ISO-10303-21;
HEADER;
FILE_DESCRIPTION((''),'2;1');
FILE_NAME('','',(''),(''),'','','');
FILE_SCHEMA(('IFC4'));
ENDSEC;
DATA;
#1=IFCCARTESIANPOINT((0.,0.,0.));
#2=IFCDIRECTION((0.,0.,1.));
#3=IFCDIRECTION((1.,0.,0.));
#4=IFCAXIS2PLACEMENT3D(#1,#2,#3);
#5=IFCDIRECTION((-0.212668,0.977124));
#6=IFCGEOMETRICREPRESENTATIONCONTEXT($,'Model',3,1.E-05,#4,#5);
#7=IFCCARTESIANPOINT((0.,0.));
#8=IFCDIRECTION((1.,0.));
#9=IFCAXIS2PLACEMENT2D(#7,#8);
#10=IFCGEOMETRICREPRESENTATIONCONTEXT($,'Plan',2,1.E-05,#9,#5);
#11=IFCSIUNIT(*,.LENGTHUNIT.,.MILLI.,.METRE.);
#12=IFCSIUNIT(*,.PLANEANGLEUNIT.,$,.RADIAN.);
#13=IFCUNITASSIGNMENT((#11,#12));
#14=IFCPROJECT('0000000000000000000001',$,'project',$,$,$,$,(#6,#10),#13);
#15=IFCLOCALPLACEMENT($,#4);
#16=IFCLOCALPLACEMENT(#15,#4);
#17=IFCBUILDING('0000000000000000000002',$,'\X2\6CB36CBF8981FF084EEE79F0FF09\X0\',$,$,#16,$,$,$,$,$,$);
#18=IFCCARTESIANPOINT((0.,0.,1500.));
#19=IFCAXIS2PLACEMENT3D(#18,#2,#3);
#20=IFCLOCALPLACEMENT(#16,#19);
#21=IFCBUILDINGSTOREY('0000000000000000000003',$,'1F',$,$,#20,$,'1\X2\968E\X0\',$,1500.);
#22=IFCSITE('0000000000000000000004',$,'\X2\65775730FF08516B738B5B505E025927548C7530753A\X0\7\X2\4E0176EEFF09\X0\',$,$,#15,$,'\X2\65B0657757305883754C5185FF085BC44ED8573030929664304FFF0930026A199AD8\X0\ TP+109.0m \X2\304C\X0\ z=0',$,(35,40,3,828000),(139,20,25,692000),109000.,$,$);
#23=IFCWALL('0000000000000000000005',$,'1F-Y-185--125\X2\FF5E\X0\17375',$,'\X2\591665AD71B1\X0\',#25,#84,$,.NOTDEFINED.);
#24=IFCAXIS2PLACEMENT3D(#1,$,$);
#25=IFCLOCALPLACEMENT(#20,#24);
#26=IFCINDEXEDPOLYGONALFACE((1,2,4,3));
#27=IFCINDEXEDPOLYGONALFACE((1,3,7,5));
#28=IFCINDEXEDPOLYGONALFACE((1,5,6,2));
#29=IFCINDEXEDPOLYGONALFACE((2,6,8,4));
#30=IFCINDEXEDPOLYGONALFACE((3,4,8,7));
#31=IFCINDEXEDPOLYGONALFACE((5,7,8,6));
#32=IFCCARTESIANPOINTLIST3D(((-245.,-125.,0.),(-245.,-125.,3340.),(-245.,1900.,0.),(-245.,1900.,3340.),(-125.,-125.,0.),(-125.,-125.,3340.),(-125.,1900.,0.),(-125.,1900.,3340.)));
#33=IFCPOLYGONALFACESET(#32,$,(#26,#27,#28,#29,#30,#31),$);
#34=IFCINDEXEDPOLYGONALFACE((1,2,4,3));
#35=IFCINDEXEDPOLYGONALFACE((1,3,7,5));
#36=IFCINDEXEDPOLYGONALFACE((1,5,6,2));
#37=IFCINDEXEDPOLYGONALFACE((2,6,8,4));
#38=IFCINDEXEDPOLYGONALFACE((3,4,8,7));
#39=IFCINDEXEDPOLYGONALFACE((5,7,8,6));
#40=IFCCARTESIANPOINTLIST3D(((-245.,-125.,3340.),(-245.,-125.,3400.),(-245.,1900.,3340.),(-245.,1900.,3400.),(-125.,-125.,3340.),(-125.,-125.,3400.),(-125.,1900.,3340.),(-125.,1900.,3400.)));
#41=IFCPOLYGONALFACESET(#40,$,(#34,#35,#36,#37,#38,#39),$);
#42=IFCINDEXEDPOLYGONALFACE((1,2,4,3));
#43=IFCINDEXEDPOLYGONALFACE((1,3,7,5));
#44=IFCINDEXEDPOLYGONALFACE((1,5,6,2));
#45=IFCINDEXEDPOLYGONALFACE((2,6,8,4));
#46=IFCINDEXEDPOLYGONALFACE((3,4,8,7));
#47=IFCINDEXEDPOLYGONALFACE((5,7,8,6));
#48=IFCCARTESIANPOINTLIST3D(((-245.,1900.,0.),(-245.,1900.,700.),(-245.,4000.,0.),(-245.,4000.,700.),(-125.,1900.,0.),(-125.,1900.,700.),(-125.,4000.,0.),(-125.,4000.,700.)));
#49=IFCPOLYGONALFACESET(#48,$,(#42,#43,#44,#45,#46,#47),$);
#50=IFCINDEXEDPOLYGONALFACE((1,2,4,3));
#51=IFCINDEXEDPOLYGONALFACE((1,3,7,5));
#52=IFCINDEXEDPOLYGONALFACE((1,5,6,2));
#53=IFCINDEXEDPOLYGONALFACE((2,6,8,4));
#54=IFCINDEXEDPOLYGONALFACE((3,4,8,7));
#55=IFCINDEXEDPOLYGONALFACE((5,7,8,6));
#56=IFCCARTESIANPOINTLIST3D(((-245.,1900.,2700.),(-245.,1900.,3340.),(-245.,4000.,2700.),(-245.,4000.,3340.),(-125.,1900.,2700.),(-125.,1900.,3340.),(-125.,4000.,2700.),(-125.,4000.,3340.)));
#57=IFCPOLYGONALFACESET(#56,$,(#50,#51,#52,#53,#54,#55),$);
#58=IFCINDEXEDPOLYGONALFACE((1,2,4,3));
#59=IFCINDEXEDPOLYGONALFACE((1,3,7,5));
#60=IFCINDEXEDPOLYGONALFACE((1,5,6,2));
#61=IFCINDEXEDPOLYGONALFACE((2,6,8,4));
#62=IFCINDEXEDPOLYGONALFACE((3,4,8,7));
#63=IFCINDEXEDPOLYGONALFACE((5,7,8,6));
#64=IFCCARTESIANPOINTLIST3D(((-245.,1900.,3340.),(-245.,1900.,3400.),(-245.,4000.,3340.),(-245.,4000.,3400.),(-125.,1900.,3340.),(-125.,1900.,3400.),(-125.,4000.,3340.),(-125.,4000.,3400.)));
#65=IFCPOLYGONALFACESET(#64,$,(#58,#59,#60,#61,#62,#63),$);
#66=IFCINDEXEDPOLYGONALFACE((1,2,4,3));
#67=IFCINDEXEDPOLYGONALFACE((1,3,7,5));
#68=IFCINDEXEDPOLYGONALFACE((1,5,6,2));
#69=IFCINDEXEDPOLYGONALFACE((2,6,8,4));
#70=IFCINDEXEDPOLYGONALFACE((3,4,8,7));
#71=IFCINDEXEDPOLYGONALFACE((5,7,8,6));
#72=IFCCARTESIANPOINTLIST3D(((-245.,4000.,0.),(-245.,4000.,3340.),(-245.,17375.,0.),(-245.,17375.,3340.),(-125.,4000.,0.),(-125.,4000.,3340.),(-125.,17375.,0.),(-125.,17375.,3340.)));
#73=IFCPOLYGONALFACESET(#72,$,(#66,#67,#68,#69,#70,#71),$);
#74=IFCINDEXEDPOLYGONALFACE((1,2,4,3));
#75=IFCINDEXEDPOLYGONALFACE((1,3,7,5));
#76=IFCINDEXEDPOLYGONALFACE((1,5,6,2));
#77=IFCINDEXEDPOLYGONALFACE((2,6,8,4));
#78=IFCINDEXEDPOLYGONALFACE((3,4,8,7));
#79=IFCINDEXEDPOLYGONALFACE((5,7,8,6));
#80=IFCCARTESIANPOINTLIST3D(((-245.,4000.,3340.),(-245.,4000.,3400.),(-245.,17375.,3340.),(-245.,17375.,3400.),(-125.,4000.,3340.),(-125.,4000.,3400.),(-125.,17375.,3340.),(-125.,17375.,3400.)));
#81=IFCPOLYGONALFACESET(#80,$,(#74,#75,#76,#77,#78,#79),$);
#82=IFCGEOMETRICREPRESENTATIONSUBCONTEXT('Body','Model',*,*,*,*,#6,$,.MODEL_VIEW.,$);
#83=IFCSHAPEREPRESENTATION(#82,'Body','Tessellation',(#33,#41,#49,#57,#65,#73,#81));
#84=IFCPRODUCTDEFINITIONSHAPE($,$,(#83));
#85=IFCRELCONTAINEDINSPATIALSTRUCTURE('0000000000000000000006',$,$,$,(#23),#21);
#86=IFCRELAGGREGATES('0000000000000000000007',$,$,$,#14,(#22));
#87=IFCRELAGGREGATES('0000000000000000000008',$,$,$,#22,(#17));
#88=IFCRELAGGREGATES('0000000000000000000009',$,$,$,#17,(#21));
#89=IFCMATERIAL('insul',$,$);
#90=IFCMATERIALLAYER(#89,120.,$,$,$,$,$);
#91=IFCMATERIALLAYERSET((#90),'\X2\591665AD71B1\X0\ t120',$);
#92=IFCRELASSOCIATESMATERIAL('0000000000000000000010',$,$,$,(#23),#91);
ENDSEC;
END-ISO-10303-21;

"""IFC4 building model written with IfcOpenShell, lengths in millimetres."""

from ifc_helpers import new_model, si_unit, direction, frame, frame_2d, origin, origin_with_axes, origin_2d_with_axis, place, context, subcontext, project, spatial, rectangle, extrude, material, layer, layer_set, layer_usage, element, save


model = new_model("IFC4")

# Units and contexts
model_context = context("Model", 3, precision=1e-05, world=origin_with_axes(), true_north=direction((-0.212668, 0.977124)))
plan_context = context("Plan", 2, precision=1e-05, world=origin_2d_with_axis(), true_north=direction((-0.212668, 0.977124)))
body_context = subcontext(model_context, "Body", "Model", "MODEL_VIEW")
ifc_project = project(units=[si_unit("LENGTHUNIT", "METRE", prefix="MILLI"), si_unit("PLANEANGLEUNIT", "RADIAN")], contexts=[model_context, plan_context])

# Site, building, storey
site_placement = place(None, origin_with_axes())
site = spatial("IfcSite", under=ifc_project, at=site_placement, Name="敷地（八王子市大和田町7丁目）", LongName="新敷地境界内（寄付地を除く）。標高 TP+109.0m が z=0", RefLatitude=(35, 40, 3, 828000), RefLongitude=(139, 20, 25, 692000), RefElevation=109000.0)
building_placement = place(site_placement, origin_with_axes())
building = spatial("IfcBuilding", under=site, at=building_placement, Name="河沿要（仮称）")
storey_placement = place(building_placement, frame((0.0, 0.0, 1500.0), z_axis=(0.0, 0.0, 1.0), x_axis=(1.0, 0.0, 0.0)))
storey = spatial("IfcBuildingStorey", under=building, at=storey_placement, Name="1F", LongName="1階", Elevation=1500.0)

# Wall
ifc_material_1 = material(Name="insul")
ifc_layer_1 = layer(ifc_material_1, 120.0)
ifc_layer_set_1 = layer_set([ifc_layer_1], Name="外断熱 t120")
ifc_layer_usage_1 = layer_usage(ifc_layer_set_1, "AXIS2", "POSITIVE", 0.0)
wall_1_placement = place(storey_placement, origin_with_axes())
element("IfcWall", 1, at=wall_1_placement, inside=storey, material=ifc_layer_usage_1, Name="1F-Y-185--125～17375", ObjectType="外断熱", PredefinedType="NOTDEFINED", context=body_context, shape_type="SweptSolid", body=[
    extrude(rectangle(XDim=120.0, YDim=2025.0, at=frame_2d((-185.0, 887.5))), origin(), (0.0, 0.0, 1.0), 3340.0),
    extrude(rectangle(XDim=120.0, YDim=2025.0, at=frame_2d((-185.0, 887.5))), frame((0.0, 0.0, 3340.0)), (0.0, 0.0, 1.0), 60.0),
    extrude(rectangle(XDim=120.0, YDim=2100.0, at=frame_2d((-185.0, 2950.0))), origin(), (0.0, 0.0, 1.0), 700.0),
    extrude(rectangle(XDim=120.0, YDim=2100.0, at=frame_2d((-185.0, 2950.0))), frame((0.0, 0.0, 2700.0)), (0.0, 0.0, 1.0), 640.0),
    extrude(rectangle(XDim=120.0, YDim=2100.0, at=frame_2d((-185.0, 2950.0))), frame((0.0, 0.0, 3340.0)), (0.0, 0.0, 1.0), 60.0),
    extrude(rectangle(XDim=120.0, YDim=13375.0, at=frame_2d((-185.0, 10687.5))), origin(), (0.0, 0.0, 1.0), 3340.0),
    extrude(rectangle(XDim=120.0, YDim=13375.0, at=frame_2d((-185.0, 10687.5))), frame((0.0, 0.0, 3340.0)), (0.0, 0.0, 1.0), 60.0),
])

save(model, "model.ifc")
